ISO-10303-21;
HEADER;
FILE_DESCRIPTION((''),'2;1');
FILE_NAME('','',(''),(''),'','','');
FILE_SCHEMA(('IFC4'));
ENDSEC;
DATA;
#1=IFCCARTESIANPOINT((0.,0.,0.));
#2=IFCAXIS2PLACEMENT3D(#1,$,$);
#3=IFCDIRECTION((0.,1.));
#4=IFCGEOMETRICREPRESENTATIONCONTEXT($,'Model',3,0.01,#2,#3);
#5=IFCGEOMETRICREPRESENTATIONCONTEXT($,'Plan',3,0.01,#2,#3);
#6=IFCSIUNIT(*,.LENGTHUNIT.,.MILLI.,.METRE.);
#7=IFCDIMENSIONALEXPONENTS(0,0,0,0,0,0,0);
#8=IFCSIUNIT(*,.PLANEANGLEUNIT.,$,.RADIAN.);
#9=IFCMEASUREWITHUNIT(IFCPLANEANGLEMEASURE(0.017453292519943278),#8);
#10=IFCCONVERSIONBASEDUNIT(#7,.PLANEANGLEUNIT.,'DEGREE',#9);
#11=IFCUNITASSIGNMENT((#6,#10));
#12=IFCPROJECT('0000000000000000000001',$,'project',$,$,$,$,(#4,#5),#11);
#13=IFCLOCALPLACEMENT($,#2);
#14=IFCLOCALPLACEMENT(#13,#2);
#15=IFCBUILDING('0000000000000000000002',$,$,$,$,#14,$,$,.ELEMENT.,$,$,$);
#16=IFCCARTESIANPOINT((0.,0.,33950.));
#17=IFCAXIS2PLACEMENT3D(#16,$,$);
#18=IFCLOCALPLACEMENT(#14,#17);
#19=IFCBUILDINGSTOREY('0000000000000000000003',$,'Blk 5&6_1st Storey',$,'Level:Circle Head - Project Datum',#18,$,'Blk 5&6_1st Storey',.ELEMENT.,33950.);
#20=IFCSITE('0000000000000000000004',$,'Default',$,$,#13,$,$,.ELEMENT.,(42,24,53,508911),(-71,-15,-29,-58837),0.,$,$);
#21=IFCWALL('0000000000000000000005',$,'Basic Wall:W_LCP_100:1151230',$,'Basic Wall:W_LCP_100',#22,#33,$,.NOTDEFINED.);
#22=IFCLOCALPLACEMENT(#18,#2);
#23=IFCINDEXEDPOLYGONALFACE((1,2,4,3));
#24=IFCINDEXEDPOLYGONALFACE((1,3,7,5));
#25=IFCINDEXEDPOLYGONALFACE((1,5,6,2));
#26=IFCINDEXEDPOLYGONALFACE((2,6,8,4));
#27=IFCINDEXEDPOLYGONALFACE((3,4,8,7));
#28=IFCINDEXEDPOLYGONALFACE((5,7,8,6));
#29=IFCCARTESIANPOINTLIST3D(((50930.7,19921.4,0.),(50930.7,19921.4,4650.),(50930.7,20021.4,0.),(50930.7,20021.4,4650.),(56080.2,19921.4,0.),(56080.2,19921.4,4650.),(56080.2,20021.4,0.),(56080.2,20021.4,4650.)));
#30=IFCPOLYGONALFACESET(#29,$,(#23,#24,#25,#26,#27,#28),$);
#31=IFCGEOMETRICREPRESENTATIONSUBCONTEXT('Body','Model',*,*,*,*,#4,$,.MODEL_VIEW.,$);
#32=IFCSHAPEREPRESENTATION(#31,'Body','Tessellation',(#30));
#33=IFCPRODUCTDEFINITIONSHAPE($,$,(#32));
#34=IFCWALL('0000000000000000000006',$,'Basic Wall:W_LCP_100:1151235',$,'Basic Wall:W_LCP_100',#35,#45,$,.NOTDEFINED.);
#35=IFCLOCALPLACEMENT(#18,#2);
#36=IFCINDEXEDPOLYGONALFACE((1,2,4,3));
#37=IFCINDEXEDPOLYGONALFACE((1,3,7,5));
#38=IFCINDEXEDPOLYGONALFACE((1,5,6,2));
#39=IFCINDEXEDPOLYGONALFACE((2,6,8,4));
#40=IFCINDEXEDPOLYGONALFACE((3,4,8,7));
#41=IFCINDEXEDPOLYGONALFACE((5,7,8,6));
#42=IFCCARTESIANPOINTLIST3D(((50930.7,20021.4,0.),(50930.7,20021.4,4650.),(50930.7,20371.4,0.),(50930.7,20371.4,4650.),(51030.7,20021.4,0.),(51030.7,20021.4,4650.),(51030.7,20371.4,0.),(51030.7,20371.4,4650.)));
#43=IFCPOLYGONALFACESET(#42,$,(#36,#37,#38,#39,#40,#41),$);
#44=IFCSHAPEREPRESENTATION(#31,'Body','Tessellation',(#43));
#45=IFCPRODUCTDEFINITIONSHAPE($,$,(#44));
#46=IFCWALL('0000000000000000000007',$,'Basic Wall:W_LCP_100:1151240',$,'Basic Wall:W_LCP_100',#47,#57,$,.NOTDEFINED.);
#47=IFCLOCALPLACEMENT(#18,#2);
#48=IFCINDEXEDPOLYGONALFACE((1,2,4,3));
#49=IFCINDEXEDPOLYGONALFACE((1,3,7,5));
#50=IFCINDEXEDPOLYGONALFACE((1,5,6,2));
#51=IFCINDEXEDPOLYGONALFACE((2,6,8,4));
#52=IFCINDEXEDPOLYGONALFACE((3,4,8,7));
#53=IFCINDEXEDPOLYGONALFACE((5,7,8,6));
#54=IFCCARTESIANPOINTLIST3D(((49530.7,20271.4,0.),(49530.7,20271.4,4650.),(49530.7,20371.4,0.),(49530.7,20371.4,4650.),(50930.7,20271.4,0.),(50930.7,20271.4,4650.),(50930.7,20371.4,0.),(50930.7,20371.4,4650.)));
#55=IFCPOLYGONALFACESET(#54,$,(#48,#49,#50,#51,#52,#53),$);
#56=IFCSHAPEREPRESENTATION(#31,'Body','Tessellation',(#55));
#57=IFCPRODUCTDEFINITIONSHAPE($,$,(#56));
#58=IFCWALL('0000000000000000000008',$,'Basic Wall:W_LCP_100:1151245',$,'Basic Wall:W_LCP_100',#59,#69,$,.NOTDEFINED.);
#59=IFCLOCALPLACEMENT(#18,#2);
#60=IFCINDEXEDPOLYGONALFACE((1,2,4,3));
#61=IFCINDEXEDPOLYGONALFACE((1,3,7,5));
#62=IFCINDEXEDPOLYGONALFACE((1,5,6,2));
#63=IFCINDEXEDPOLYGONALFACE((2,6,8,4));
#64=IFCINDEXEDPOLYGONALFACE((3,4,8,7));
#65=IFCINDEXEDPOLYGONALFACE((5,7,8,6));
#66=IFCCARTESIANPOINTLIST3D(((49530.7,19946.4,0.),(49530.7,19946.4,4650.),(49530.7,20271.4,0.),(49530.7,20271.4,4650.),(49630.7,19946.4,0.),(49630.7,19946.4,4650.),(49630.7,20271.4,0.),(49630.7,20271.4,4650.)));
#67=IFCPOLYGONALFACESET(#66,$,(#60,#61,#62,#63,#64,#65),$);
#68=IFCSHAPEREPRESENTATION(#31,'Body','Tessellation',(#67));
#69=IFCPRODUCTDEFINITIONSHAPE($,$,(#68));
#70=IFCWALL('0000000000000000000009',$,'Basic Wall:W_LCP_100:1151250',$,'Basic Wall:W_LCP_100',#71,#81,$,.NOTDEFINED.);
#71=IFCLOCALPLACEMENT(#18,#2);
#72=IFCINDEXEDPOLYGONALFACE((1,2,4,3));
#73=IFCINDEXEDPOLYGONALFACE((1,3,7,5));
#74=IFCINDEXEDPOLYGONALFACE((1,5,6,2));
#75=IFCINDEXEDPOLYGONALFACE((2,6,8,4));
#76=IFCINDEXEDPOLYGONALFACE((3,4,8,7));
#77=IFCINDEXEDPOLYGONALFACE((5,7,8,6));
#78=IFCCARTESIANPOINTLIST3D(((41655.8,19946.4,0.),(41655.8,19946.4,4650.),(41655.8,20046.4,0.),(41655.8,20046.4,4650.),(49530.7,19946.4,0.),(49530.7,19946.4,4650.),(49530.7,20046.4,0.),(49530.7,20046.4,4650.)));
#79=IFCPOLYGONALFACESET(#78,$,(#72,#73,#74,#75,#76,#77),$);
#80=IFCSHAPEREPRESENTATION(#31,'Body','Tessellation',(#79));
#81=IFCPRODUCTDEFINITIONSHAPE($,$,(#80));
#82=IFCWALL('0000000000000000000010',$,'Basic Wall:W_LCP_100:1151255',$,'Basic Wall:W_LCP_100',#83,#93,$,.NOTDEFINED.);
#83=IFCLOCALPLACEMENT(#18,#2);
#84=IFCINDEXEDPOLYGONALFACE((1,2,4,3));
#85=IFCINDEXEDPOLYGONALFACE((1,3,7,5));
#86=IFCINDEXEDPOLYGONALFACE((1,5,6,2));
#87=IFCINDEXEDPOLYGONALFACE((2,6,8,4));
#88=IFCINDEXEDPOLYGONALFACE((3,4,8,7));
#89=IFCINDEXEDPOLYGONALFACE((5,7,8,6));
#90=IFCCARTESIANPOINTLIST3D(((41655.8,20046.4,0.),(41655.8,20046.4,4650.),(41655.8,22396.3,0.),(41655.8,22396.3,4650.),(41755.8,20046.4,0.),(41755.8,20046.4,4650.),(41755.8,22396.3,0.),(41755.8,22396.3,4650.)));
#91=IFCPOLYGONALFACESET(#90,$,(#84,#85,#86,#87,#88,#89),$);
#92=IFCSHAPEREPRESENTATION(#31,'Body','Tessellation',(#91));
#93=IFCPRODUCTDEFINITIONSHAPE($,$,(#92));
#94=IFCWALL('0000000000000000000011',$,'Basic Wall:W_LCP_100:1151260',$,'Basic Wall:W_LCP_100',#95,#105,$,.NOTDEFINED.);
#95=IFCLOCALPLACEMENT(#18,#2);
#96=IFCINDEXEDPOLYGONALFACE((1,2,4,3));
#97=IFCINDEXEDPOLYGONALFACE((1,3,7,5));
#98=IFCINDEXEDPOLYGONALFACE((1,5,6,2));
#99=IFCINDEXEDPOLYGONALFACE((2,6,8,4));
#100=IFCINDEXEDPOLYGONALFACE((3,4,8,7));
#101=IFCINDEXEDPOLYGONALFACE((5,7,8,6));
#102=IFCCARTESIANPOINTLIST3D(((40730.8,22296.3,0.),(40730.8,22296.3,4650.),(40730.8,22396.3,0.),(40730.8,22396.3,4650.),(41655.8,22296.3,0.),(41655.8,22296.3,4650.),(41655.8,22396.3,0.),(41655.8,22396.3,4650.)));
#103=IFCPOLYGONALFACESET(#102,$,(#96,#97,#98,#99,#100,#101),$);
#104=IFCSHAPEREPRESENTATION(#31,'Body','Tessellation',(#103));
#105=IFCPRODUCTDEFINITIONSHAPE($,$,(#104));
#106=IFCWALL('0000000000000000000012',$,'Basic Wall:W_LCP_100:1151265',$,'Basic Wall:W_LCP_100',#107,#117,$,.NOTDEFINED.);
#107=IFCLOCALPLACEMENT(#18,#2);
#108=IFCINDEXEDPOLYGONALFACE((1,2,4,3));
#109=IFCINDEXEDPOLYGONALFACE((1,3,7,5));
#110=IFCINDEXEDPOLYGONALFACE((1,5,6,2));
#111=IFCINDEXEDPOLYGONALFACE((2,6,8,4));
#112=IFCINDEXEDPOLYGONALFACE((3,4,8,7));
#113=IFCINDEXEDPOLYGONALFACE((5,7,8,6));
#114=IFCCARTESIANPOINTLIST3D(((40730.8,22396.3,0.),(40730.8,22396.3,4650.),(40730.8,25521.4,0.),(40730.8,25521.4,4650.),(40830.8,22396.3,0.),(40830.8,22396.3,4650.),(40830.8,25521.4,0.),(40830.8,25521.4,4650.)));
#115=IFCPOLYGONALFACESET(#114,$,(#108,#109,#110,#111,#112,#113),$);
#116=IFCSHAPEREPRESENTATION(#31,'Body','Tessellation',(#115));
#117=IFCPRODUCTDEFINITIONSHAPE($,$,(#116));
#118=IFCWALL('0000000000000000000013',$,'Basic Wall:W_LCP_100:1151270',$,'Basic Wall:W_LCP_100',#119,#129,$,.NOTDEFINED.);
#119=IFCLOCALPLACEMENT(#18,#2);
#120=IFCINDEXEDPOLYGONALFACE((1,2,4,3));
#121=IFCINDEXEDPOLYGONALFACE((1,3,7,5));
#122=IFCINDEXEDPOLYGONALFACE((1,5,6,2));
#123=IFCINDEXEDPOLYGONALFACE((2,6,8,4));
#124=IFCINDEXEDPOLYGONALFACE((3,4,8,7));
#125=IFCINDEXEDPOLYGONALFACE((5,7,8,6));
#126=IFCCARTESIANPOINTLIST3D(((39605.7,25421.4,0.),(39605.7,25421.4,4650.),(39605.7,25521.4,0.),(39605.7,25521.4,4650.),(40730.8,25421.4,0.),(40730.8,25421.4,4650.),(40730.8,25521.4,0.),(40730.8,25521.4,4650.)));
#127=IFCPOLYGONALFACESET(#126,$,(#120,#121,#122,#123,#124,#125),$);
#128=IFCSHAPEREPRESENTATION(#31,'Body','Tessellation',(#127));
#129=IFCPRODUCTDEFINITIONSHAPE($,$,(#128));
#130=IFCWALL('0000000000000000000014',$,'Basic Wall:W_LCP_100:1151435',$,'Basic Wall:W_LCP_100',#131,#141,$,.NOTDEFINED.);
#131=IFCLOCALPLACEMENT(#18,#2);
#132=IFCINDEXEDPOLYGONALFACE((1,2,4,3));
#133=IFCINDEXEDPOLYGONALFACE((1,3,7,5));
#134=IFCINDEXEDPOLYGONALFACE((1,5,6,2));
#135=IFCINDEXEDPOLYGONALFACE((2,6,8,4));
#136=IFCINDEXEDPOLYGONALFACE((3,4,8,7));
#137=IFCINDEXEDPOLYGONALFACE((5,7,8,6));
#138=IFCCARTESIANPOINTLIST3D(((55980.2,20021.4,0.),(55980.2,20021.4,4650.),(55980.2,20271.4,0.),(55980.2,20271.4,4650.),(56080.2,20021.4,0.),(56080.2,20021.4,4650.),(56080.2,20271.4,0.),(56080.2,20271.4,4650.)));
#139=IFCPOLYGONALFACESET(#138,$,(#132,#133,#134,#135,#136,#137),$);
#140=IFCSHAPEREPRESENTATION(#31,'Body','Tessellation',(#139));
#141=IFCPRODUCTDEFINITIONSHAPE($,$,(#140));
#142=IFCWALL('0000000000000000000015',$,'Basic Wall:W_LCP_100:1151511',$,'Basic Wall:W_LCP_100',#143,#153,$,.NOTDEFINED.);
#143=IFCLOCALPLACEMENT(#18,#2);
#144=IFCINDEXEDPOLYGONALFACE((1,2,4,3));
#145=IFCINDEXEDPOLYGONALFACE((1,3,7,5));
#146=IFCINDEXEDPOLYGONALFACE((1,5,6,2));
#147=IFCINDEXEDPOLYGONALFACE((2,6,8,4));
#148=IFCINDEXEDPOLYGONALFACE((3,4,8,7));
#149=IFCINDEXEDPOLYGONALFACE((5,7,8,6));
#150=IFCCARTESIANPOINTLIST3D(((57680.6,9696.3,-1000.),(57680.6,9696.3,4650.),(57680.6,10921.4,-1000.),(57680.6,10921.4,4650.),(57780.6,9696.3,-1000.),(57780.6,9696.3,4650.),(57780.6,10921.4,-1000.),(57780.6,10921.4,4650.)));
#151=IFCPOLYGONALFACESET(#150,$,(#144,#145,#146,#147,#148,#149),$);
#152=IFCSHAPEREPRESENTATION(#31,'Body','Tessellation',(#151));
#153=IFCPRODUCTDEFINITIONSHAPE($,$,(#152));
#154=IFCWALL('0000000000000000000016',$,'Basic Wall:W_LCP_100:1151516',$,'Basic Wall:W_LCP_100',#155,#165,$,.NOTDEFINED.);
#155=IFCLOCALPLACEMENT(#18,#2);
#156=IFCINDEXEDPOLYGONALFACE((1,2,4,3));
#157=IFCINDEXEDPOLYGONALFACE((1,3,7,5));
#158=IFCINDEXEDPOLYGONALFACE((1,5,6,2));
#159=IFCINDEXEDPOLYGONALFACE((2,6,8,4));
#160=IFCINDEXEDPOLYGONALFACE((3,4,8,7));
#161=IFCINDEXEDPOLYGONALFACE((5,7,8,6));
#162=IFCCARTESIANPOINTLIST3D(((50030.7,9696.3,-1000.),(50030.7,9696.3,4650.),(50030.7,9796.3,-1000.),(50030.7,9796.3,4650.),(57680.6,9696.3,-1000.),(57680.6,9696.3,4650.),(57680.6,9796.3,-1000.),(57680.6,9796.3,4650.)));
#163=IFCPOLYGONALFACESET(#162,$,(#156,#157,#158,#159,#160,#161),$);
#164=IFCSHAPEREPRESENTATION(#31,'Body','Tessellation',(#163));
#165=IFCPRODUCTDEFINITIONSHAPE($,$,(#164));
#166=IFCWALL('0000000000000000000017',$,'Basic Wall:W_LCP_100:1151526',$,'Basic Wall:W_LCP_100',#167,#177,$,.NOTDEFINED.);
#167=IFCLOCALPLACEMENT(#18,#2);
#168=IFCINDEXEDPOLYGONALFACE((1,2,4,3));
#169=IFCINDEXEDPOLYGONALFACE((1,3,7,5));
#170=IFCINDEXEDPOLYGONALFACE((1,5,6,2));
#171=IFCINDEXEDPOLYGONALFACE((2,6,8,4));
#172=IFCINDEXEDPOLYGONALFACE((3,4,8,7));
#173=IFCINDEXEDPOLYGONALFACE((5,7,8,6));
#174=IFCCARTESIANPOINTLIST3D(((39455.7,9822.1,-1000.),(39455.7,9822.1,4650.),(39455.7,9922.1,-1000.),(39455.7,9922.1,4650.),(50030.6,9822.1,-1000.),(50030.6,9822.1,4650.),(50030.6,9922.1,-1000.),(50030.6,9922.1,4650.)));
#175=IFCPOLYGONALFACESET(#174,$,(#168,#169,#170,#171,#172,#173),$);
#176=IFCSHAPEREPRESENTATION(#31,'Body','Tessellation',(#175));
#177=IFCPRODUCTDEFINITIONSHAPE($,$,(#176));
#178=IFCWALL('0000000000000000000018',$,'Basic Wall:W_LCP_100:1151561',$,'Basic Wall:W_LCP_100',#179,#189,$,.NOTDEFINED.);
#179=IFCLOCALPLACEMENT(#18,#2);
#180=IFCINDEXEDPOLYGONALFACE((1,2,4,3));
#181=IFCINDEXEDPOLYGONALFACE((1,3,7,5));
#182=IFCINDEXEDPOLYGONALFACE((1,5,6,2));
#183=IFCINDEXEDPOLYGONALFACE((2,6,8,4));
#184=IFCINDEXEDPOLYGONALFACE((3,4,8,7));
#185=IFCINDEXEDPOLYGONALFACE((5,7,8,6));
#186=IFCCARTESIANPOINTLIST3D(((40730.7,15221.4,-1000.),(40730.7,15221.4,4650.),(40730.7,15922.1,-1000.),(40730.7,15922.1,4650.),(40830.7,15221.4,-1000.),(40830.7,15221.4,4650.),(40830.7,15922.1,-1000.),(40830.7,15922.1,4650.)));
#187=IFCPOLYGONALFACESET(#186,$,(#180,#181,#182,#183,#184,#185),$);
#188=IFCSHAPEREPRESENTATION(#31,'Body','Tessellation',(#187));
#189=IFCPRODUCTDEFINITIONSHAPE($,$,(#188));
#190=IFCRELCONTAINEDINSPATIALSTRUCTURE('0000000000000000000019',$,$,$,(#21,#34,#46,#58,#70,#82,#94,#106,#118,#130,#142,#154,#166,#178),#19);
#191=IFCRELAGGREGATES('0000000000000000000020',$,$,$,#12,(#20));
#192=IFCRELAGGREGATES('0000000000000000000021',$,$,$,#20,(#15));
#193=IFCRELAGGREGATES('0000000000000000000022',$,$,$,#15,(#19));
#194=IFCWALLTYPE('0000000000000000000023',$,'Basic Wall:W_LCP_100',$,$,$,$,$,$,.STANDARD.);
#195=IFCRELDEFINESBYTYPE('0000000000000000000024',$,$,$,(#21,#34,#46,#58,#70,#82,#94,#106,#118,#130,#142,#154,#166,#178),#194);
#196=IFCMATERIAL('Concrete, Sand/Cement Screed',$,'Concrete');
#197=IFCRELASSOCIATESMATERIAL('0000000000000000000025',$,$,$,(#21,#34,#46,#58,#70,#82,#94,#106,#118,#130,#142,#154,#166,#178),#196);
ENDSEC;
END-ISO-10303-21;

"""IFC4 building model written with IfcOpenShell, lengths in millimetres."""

from ifc_helpers import new_model, entity, si_unit, converted_unit, direction, frame, origin, place, context, subcontext, project, spatial, indexed_curve, outline, extrude, material, type_object, element, save


model = new_model("IFC4")

# Units and contexts
model_context = context("Model", 3, precision=0.01, world=origin(), true_north=direction((0.0, 1.0)))
plan_context = context("Plan", 3, precision=0.01, world=origin(), true_north=direction((0.0, 1.0)))
body_context = subcontext(model_context, "Body", "Model", "MODEL_VIEW")
ifc_project = project(units=[si_unit("LENGTHUNIT", "METRE", prefix="MILLI"), converted_unit("PLANEANGLEUNIT", "DEGREE", entity("IfcPlaneAngleMeasure", 0.017453292519943278), si_unit("PLANEANGLEUNIT", "RADIAN"), dimensions=[0, 0, 0, 0, 0, 0, 0])], contexts=[model_context, plan_context])

# Site, building, storey
site_placement = place(None, origin())
site = spatial("IfcSite", under=ifc_project, at=site_placement, Name="Default", CompositionType="ELEMENT", RefLatitude=(42, 24, 53, 508911), RefLongitude=(-71, -15, -29, -58837), RefElevation=0.0)
building_placement = place(site_placement, origin())
building = spatial("IfcBuilding", under=site, at=building_placement, CompositionType="ELEMENT")
storey_placement = place(building_placement, frame((0.0, 0.0, 33950.0)))
storey = spatial("IfcBuildingStorey", under=building, at=storey_placement, Name="Blk 5&6_1st Storey", ObjectType="Level:Circle Head - Project Datum", LongName="Blk 5&6_1st Storey", CompositionType="ELEMENT", Elevation=33950.0)

# Walls
ifc_material = material(Name="Concrete, Sand/Cement Screed", Category="Concrete")
wall_type = type_object("IfcWallType", Name="Basic Wall:W_LCP_100", PredefinedType="STANDARD")
wall_1_placement = place(storey_placement, frame((56080.2, 19971.4, 0.0), z_axis=(0.0, 0.0, 1.0), x_axis=(-1.0, 0.0, 0.0)))
element("IfcWall", 1, at=wall_1_placement, inside=storey, type_object=wall_type, material=ifc_material, Name="Basic Wall:W_LCP_100:1151230", ObjectType="Basic Wall:W_LCP_100", PredefinedType="NOTDEFINED", context=body_context, shape_type="SweptSolid", body=[
    extrude(outline(indexed_curve([(5149.5, 50.0), (0.0, 50.0), (0.0, -50.0), (5149.5, -50.0), (5149.5, 50.0)], self_intersect=False)), origin(), (0.0, 0.0, 1.0), 4650.0),
])
wall_2_placement = place(storey_placement, frame((50980.7, 20021.4, 0.0), z_axis=(0.0, 0.0, 1.0), x_axis=(0.0, 1.0, 0.0)))
element("IfcWall", 2, at=wall_2_placement, inside=storey, type_object=wall_type, material=ifc_material, Name="Basic Wall:W_LCP_100:1151235", ObjectType="Basic Wall:W_LCP_100", PredefinedType="NOTDEFINED", context=body_context, shape_type="SweptSolid", body=[
    extrude(outline(indexed_curve([(350.0, 50.0), (0.0, 50.0), (0.0, -50.0), (350.0, -50.0), (350.0, 50.0)], self_intersect=False)), origin(), (0.0, 0.0, 1.0), 4650.0),
])
wall_3_placement = place(storey_placement, frame((50930.7, 20321.4, 0.0), z_axis=(0.0, 0.0, 1.0), x_axis=(-1.0, 0.0, 0.0)))
element("IfcWall", 3, at=wall_3_placement, inside=storey, type_object=wall_type, material=ifc_material, Name="Basic Wall:W_LCP_100:1151240", ObjectType="Basic Wall:W_LCP_100", PredefinedType="NOTDEFINED", context=body_context, shape_type="SweptSolid", body=[
    extrude(outline(indexed_curve([(1400.0, 50.0), (0.0, 50.0), (0.0, -50.0), (1400.0, -50.0), (1400.0, 50.0)], self_intersect=False)), origin(), (0.0, 0.0, 1.0), 4650.0),
])
wall_4_placement = place(storey_placement, frame((49580.7, 20271.4, 0.0), z_axis=(0.0, 0.0, 1.0), x_axis=(0.0, -1.0, 0.0)))
element("IfcWall", 4, at=wall_4_placement, inside=storey, type_object=wall_type, material=ifc_material, Name="Basic Wall:W_LCP_100:1151245", ObjectType="Basic Wall:W_LCP_100", PredefinedType="NOTDEFINED", context=body_context, shape_type="SweptSolid", body=[
    extrude(outline(indexed_curve([(325.0, 50.0), (0.0, 50.0), (0.0, -50.0), (325.0, -50.0), (325.0, 50.0)], self_intersect=False)), origin(), (0.0, 0.0, 1.0), 4650.0),
])
wall_5_placement = place(storey_placement, frame((49530.7, 19996.4, 0.0), z_axis=(0.0, 0.0, 1.0), x_axis=(-1.0, 0.0, 0.0)))
element("IfcWall", 5, at=wall_5_placement, inside=storey, type_object=wall_type, material=ifc_material, Name="Basic Wall:W_LCP_100:1151250", ObjectType="Basic Wall:W_LCP_100", PredefinedType="NOTDEFINED", context=body_context, shape_type="SweptSolid", body=[
    extrude(outline(indexed_curve([(7874.8, 50.0), (0.0, 50.0), (0.0, -50.0), (7874.8, -50.0), (7874.8, 50.0)], self_intersect=False)), origin(), (0.0, 0.0, 1.0), 4650.0),
])
wall_6_placement = place(storey_placement, frame((41705.8, 20046.4, 0.0), z_axis=(0.0, 0.0, 1.0), x_axis=(0.0, 1.0, 0.0)))
element("IfcWall", 6, at=wall_6_placement, inside=storey, type_object=wall_type, material=ifc_material, Name="Basic Wall:W_LCP_100:1151255", ObjectType="Basic Wall:W_LCP_100", PredefinedType="NOTDEFINED", context=body_context, shape_type="SweptSolid", body=[
    extrude(outline(indexed_curve([(2350.0, 50.0), (0.0, 50.0), (0.0, -50.0), (2350.0, -50.0), (2350.0, 50.0)], self_intersect=False)), origin(), (0.0, 0.0, 1.0), 4650.0),
])
wall_7_placement = place(storey_placement, frame((41655.8, 22346.3, 0.0), z_axis=(0.0, 0.0, 1.0), x_axis=(-1.0, 0.0, 0.0)))
element("IfcWall", 7, at=wall_7_placement, inside=storey, type_object=wall_type, material=ifc_material, Name="Basic Wall:W_LCP_100:1151260", ObjectType="Basic Wall:W_LCP_100", PredefinedType="NOTDEFINED", context=body_context, shape_type="SweptSolid", body=[
    extrude(outline(indexed_curve([(925.0, 50.0), (0.0, 50.0), (0.0, -50.0), (925.0, -50.0), (925.0, 50.0)], self_intersect=False)), origin(), (0.0, 0.0, 1.0), 4650.0),
])
wall_8_placement = place(storey_placement, frame((40780.8, 22396.3, 0.0), z_axis=(0.0, 0.0, 1.0), x_axis=(0.0, 1.0, 0.0)))
element("IfcWall", 8, at=wall_8_placement, inside=storey, type_object=wall_type, material=ifc_material, Name="Basic Wall:W_LCP_100:1151265", ObjectType="Basic Wall:W_LCP_100", PredefinedType="NOTDEFINED", context=body_context, shape_type="SweptSolid", body=[
    extrude(outline(indexed_curve([(3125.0, 50.0), (0.0, 50.0), (0.0, -50.0), (3125.0, -50.0), (3125.0, 50.0)], self_intersect=False)), origin(), (0.0, 0.0, 1.0), 4650.0),
])
wall_9_placement = place(storey_placement, frame((40730.8, 25471.4, 0.0), z_axis=(0.0, 0.0, 1.0), x_axis=(-1.0, 0.0, 0.0)))
element("IfcWall", 9, at=wall_9_placement, inside=storey, type_object=wall_type, material=ifc_material, Name="Basic Wall:W_LCP_100:1151270", ObjectType="Basic Wall:W_LCP_100", PredefinedType="NOTDEFINED", context=body_context, shape_type="SweptSolid", body=[
    extrude(outline(indexed_curve([(1125.2, 50.0), (0.0, 50.0), (0.0, -50.0), (1125.2, -50.0), (1125.2, 50.0)], self_intersect=False)), origin(), (0.0, 0.0, 1.0), 4650.0),
])
wall_10_placement = place(storey_placement, frame((56030.2, 20271.4, 0.0), z_axis=(0.0, 0.0, 1.0), x_axis=(0.0, -1.0, 0.0)))
element("IfcWall", 10, at=wall_10_placement, inside=storey, type_object=wall_type, material=ifc_material, Name="Basic Wall:W_LCP_100:1151435", ObjectType="Basic Wall:W_LCP_100", PredefinedType="NOTDEFINED", context=body_context, shape_type="SweptSolid", body=[
    extrude(outline(indexed_curve([(250.0, 50.0), (0.0, 50.0), (0.0, -50.0), (250.0, -50.0), (250.0, 50.0)], self_intersect=False)), origin(), (0.0, 0.0, 1.0), 4650.0),
])
wall_11_placement = place(storey_placement, frame((57730.6, 10921.4, -1000.0), z_axis=(0.0, 0.0, 1.0), x_axis=(0.0, -1.0, 0.0)))
element("IfcWall", 11, at=wall_11_placement, inside=storey, type_object=wall_type, material=ifc_material, Name="Basic Wall:W_LCP_100:1151511", ObjectType="Basic Wall:W_LCP_100", PredefinedType="NOTDEFINED", context=body_context, shape_type="SweptSolid", body=[
    extrude(outline(indexed_curve([(1225.1, 50.0), (0.0, 50.0), (0.0, -50.0), (1225.1, -50.0), (1225.1, 50.0)], self_intersect=False)), origin(), (0.0, 0.0, 1.0), 5650.0),
])
wall_12_placement = place(storey_placement, frame((57680.6, 9746.3, -1000.0), z_axis=(0.0, 0.0, 1.0), x_axis=(-1.0, 0.0, 0.0)))
element("IfcWall", 12, at=wall_12_placement, inside=storey, type_object=wall_type, material=ifc_material, Name="Basic Wall:W_LCP_100:1151516", ObjectType="Basic Wall:W_LCP_100", PredefinedType="NOTDEFINED", context=body_context, shape_type="SweptSolid", body=[
    extrude(outline(indexed_curve([(7649.9, 50.0), (0.0, 50.0), (0.0, -50.0), (7649.9, -50.0), (7649.9, 50.0)], self_intersect=False)), origin(), (0.0, 0.0, 1.0), 5650.0),
])
wall_13_placement = place(storey_placement, frame((50030.6, 9872.1, -1000.0), z_axis=(0.0, 0.0, 1.0), x_axis=(-1.0, 0.0, 0.0)))
element("IfcWall", 13, at=wall_13_placement, inside=storey, type_object=wall_type, material=ifc_material, Name="Basic Wall:W_LCP_100:1151526", ObjectType="Basic Wall:W_LCP_100", PredefinedType="NOTDEFINED", context=body_context, shape_type="SweptSolid", body=[
    extrude(outline(indexed_curve([(10574.9, 50.0), (0.0, 50.0), (0.0, -50.0), (10574.9, -50.0), (10574.9, 50.0)], self_intersect=False)), origin(), (0.0, 0.0, 1.0), 5650.0),
])
wall_14_placement = place(storey_placement, frame((40780.7, 15922.1, -1000.0), z_axis=(0.0, 0.0, 1.0), x_axis=(0.0, -1.0, 0.0)))
element("IfcWall", 14, at=wall_14_placement, inside=storey, type_object=wall_type, material=ifc_material, Name="Basic Wall:W_LCP_100:1151561", ObjectType="Basic Wall:W_LCP_100", PredefinedType="NOTDEFINED", context=body_context, shape_type="SweptSolid", body=[
    extrude(outline(indexed_curve([(700.7, 50.0), (0.0, 50.0), (0.0, -50.0), (700.7, -50.0), (700.7, 50.0)], self_intersect=False)), origin(), (0.0, 0.0, 1.0), 5650.0),
])

save(model, "model.ifc")
